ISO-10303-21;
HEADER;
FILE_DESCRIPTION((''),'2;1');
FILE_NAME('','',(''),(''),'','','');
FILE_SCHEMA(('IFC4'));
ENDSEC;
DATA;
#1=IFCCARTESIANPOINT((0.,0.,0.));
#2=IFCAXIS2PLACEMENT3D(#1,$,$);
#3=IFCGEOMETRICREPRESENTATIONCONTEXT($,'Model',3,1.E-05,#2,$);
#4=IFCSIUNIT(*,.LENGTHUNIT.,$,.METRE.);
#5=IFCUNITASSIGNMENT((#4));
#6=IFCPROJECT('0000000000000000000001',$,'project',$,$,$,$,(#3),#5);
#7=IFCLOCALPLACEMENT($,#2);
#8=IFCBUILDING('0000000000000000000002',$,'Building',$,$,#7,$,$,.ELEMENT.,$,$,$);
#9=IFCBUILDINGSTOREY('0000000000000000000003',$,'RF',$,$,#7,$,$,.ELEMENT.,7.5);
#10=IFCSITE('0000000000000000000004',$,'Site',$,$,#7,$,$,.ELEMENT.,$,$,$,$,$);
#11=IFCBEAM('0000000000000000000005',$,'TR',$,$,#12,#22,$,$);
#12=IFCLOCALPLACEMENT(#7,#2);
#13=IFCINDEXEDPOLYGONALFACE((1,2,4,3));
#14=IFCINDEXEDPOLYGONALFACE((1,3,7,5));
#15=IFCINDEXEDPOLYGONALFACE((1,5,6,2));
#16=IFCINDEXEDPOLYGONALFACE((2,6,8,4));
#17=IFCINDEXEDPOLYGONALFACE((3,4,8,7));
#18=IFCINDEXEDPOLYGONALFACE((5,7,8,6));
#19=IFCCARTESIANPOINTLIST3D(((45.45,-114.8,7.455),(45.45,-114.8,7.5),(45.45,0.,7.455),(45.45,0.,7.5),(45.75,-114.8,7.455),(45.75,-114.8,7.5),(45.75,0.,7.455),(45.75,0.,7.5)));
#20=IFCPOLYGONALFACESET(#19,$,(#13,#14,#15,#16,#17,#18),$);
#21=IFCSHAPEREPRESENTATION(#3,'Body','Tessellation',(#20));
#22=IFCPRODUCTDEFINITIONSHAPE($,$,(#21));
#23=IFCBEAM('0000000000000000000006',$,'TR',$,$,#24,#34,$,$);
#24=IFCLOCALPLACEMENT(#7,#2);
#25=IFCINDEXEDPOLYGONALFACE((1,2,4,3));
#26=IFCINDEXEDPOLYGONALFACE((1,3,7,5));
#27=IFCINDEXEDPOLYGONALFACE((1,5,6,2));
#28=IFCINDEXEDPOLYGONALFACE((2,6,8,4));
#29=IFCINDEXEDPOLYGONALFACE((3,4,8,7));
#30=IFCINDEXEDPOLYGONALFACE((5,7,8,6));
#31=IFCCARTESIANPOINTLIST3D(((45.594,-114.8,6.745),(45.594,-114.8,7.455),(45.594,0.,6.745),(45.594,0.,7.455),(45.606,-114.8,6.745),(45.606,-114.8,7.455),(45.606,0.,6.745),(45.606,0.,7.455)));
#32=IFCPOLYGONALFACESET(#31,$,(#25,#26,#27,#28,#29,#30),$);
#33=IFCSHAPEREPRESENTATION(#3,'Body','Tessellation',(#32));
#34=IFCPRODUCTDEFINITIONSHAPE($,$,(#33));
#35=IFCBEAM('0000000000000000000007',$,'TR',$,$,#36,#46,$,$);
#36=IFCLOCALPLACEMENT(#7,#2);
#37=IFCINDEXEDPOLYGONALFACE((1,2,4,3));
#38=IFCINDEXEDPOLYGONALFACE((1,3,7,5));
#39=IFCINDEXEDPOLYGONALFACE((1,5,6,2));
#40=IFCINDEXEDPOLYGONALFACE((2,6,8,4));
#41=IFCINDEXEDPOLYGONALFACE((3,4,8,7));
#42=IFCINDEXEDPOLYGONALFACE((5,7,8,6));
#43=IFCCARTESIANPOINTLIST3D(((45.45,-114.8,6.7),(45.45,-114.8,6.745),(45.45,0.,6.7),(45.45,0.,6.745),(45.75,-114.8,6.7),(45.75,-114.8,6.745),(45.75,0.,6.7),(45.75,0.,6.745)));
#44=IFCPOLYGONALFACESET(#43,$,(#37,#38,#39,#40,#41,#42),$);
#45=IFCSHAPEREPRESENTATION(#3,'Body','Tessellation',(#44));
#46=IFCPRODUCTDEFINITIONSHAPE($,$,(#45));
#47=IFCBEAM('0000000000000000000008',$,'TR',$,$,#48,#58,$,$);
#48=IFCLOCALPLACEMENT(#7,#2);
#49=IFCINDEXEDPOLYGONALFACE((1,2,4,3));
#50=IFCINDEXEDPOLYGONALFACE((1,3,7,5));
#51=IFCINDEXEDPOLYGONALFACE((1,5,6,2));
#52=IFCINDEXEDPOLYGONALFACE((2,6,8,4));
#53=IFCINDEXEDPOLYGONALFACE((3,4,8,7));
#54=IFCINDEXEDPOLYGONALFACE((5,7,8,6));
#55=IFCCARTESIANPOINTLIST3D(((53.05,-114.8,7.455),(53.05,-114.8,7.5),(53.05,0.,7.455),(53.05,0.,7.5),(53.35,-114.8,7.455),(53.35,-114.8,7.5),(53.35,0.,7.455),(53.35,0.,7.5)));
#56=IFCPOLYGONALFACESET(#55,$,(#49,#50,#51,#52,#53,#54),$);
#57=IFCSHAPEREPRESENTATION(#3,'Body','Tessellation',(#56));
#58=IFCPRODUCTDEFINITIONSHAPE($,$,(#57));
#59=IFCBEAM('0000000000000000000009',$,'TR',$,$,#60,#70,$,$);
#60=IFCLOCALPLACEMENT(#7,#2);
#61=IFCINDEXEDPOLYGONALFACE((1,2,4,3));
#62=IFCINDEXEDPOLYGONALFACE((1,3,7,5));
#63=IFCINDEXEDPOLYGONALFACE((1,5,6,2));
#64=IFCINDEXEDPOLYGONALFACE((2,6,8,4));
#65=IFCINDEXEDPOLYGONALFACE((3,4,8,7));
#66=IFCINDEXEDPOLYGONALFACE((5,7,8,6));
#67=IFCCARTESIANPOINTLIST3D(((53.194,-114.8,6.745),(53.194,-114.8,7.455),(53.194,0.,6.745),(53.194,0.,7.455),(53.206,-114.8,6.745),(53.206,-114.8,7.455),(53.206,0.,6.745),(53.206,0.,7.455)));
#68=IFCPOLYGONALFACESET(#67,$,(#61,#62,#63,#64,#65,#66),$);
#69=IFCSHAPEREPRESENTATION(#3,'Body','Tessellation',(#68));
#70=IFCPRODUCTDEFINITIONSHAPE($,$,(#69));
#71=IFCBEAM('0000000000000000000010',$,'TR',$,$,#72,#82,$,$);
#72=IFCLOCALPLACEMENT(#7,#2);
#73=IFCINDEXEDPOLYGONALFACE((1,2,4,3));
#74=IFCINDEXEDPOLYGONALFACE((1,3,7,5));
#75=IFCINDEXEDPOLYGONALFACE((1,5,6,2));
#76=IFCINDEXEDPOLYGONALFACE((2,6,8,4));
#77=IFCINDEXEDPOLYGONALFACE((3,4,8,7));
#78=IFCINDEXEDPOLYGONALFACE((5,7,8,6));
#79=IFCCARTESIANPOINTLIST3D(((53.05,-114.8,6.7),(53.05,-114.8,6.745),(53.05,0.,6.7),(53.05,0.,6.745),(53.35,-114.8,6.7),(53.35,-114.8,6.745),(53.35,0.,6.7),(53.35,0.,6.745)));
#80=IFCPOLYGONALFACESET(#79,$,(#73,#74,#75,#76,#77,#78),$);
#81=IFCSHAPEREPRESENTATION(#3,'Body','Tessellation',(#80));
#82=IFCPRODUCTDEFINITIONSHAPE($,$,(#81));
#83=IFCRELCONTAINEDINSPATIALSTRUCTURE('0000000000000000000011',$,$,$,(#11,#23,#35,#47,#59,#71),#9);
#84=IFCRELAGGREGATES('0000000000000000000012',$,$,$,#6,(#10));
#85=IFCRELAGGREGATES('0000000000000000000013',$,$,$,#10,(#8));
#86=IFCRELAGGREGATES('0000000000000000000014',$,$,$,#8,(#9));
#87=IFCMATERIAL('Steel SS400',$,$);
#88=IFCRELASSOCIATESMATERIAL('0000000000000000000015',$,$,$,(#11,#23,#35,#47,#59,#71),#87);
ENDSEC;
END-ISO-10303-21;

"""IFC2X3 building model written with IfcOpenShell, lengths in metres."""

from ifc_helpers import new_model, si_unit, frame, origin, origin_2d, place, context, project, spatial, rectangle, extrude, material, element, save


model = new_model("IFC2X3")

# Units and contexts
model_context = context("Model", 3, precision=1e-05, world=origin())
ifc_project = project(units=[si_unit("LENGTHUNIT", "METRE")], contexts=[model_context])

# Site, building, storey
placement = place(None, origin())
site = spatial("IfcSite", under=ifc_project, at=placement, Name="Site", CompositionType="ELEMENT")
building = spatial("IfcBuilding", under=site, at=placement, Name="Building", CompositionType="ELEMENT")
storey = spatial("IfcBuildingStorey", under=building, at=placement, Name="RF", CompositionType="ELEMENT", Elevation=7.5)

# Beams
ifc_material = material(Name="Steel SS400")
for number, where, name in (
    (1, (45.6, -57.4, 7.455), "TR"),
):
    element("IfcBeam", number, at=place(None, frame(where)), inside=storey, material=ifc_material, Name=name, context=model_context, shape_type="SweptSolid", body=[
        extrude(rectangle(XDim=0.3, YDim=114.8, at=origin_2d()), origin(), (0.0, 0.0, 1.0), 0.045),
    ])
beam_1_placement = place(None, frame((45.6, -57.4, 6.745)))
element("IfcBeam", 2, at=beam_1_placement, inside=storey, material=ifc_material, Name="TR", context=model_context, shape_type="SweptSolid", body=[
    extrude(rectangle(XDim=0.012, YDim=114.8, at=origin_2d()), origin(), (0.0, 0.0, 1.0), 0.71),
])
for number, where, name in (
    (3, (45.6, -57.4, 6.7), "TR"),
    (4, (53.2, -57.4, 7.455), "TR"),
):
    element("IfcBeam", number, at=place(None, frame(where)), inside=storey, material=ifc_material, Name=name, context=model_context, shape_type="SweptSolid", body=[
        extrude(rectangle(XDim=0.3, YDim=114.8, at=origin_2d()), origin(), (0.0, 0.0, 1.0), 0.045),
    ])
beam_2_placement = place(None, frame((53.2, -57.4, 6.745)))
element("IfcBeam", 5, at=beam_2_placement, inside=storey, material=ifc_material, Name="TR", context=model_context, shape_type="SweptSolid", body=[
    extrude(rectangle(XDim=0.012, YDim=114.8, at=origin_2d()), origin(), (0.0, 0.0, 1.0), 0.71),
])
beam_3_placement = place(None, frame((53.2, -57.4, 6.7)))
element("IfcBeam", 6, at=beam_3_placement, inside=storey, material=ifc_material, Name="TR", context=model_context, shape_type="SweptSolid", body=[
    extrude(rectangle(XDim=0.3, YDim=114.8, at=origin_2d()), origin(), (0.0, 0.0, 1.0), 0.045),
])

save(model, "model.ifc")
